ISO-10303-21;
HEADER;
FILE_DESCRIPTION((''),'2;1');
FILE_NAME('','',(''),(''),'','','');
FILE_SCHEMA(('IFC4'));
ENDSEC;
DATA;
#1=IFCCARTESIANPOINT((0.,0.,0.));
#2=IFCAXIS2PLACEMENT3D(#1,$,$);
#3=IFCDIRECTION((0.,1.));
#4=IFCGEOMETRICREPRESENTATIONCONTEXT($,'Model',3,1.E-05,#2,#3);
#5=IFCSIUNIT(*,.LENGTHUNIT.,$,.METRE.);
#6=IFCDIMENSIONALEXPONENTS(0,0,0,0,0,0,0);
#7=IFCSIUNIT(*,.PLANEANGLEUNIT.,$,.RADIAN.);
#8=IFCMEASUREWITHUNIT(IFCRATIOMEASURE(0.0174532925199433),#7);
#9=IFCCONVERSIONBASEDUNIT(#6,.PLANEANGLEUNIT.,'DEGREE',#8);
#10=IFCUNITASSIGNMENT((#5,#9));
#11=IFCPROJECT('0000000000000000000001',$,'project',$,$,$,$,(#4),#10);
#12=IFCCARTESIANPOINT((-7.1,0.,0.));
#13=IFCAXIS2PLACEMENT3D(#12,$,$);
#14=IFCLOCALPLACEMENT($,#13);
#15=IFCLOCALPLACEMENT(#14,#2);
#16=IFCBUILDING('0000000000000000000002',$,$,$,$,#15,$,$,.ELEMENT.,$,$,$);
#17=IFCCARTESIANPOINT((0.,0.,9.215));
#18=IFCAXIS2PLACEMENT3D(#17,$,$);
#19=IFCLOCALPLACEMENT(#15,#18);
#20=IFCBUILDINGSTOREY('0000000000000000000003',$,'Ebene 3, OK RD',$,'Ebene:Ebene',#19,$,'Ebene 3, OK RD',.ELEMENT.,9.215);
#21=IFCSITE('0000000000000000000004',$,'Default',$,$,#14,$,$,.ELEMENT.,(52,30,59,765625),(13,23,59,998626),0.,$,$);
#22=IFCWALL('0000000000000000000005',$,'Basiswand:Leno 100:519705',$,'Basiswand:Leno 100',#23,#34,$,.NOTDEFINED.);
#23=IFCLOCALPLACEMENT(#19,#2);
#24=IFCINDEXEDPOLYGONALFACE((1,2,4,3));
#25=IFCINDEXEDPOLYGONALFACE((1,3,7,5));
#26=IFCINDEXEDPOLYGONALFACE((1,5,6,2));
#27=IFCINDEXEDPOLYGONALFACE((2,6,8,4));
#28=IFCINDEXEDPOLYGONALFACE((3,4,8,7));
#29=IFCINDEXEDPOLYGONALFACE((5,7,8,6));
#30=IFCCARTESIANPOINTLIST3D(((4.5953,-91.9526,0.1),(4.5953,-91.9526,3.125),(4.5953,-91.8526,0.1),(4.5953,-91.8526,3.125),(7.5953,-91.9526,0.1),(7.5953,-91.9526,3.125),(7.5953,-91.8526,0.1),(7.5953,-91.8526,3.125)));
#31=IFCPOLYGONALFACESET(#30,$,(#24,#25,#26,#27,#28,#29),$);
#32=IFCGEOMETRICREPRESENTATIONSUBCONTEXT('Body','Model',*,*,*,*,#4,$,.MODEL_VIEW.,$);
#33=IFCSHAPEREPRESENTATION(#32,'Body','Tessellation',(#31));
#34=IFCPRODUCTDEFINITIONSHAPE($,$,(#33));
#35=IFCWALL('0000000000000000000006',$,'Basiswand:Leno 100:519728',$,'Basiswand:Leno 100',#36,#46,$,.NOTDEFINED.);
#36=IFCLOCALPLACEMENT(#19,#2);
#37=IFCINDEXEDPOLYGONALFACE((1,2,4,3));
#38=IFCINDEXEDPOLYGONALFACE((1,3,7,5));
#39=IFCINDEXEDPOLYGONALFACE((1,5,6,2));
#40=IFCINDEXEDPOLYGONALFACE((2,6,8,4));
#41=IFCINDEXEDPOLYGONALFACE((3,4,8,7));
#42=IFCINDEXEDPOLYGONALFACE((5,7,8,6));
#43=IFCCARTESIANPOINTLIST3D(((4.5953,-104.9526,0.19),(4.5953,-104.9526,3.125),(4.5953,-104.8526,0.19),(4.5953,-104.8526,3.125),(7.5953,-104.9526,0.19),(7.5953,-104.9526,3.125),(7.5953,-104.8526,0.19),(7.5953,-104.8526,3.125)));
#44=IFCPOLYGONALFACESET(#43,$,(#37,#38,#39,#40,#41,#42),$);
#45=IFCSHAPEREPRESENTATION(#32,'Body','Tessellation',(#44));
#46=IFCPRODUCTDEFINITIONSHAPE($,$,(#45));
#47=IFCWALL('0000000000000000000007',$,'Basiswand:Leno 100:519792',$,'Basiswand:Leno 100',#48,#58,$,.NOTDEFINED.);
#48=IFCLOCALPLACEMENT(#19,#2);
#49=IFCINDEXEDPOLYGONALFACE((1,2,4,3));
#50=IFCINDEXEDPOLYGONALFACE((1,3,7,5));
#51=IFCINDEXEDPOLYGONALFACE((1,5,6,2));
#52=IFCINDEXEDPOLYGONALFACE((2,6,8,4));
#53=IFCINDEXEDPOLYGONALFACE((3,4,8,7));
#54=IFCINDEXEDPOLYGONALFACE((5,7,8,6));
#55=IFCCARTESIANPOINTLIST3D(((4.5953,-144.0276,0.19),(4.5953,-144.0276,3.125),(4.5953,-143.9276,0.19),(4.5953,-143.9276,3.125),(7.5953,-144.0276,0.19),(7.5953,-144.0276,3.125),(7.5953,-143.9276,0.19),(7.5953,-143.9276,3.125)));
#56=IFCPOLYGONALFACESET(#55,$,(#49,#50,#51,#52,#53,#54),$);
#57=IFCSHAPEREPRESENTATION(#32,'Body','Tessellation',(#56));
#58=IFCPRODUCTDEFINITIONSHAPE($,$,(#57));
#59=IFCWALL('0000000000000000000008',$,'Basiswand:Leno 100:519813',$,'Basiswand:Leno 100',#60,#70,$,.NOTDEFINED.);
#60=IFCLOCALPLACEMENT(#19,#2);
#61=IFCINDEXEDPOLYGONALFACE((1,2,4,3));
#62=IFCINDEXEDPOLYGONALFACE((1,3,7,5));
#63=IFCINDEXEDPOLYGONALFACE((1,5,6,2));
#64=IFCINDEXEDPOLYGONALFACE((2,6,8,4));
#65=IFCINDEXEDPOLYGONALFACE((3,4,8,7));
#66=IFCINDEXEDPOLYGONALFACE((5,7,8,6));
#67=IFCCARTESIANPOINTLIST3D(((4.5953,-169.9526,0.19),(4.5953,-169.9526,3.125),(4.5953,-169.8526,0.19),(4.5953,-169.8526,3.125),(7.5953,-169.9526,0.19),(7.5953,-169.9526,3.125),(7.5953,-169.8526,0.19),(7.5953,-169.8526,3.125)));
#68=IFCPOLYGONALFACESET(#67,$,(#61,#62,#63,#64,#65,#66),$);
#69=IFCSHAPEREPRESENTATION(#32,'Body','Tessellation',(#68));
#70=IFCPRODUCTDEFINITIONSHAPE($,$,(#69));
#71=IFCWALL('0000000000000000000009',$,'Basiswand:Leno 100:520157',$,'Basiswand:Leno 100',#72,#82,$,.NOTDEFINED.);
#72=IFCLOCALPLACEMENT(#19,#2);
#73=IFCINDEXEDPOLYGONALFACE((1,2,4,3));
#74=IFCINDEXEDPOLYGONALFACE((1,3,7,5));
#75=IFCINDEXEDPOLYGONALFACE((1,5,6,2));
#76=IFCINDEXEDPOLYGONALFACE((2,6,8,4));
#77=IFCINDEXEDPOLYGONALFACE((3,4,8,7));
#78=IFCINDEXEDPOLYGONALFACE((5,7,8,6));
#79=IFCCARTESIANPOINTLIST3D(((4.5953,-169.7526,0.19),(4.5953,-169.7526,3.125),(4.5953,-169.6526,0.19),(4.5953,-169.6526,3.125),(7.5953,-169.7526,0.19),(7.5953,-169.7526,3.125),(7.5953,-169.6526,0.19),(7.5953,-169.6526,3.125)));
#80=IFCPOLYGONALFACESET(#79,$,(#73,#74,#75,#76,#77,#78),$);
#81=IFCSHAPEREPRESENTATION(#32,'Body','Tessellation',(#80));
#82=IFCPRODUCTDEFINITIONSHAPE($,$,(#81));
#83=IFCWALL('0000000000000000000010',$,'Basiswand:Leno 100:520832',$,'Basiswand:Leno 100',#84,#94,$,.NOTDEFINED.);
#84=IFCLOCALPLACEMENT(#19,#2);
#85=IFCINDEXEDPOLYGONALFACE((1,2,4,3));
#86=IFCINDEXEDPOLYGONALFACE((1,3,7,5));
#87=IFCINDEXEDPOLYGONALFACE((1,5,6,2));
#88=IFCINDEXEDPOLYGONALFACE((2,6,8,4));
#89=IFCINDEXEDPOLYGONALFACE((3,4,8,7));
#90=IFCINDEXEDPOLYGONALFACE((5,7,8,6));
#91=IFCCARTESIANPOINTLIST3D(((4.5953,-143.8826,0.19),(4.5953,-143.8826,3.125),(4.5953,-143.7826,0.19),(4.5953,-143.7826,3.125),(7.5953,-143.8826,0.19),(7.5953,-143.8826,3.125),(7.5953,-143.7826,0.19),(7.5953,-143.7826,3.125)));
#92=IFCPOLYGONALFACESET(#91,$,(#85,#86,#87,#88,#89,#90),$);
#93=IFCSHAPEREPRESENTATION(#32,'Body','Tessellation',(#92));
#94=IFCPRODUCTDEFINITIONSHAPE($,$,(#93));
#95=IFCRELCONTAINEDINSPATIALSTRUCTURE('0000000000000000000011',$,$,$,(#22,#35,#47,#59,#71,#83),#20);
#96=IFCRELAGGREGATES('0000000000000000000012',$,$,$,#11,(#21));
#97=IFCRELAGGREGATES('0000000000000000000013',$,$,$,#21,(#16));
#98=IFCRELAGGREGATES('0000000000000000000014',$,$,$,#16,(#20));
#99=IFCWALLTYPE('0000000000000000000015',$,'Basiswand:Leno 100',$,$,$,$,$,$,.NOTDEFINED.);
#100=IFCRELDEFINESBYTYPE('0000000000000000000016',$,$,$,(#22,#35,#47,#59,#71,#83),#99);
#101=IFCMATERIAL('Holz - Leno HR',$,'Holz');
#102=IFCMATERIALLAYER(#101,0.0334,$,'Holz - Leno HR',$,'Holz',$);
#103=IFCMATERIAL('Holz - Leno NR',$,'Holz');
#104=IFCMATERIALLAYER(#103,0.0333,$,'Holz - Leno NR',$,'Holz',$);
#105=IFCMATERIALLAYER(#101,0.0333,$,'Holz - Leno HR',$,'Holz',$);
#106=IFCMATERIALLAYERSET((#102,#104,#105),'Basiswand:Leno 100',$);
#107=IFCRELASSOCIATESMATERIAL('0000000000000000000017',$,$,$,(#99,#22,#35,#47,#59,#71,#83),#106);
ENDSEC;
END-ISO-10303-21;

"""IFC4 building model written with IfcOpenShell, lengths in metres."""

from ifc_helpers import new_model, entity, si_unit, converted_unit, direction, frame, origin, place, context, subcontext, project, spatial, indexed_curve, outline, extrude, material, layer, layer_set, type_object, element, save


model = new_model("IFC4")

# Units and contexts
model_context = context("Model", 3, precision=1e-05, world=origin(), true_north=direction((0.0, 1.0)))
body_context = subcontext(model_context, "Body", "Model", "MODEL_VIEW")
ifc_project = project(units=[si_unit("LENGTHUNIT", "METRE"), converted_unit("PLANEANGLEUNIT", "DEGREE", entity("IfcRatioMeasure", 0.0174532925199433), si_unit("PLANEANGLEUNIT", "RADIAN"), dimensions=[0, 0, 0, 0, 0, 0, 0])], contexts=[model_context])

# Site, building, storey
site_placement = place(None, frame((-7.1, 0.0, 0.0)))
site = spatial("IfcSite", under=ifc_project, at=site_placement, Name="Default", CompositionType="ELEMENT", RefLatitude=(52, 30, 59, 765625), RefLongitude=(13, 23, 59, 998626), RefElevation=0.0)
building_placement = place(site_placement, origin())
building = spatial("IfcBuilding", under=site, at=building_placement, CompositionType="ELEMENT")
storey_placement = place(building_placement, frame((0.0, 0.0, 9.215)))
storey = spatial("IfcBuildingStorey", under=building, at=storey_placement, Name="Ebene 3, OK RD", ObjectType="Ebene:Ebene", LongName="Ebene 3, OK RD", CompositionType="ELEMENT", Elevation=9.215)

# Shared definitions
ifc_material_1 = material(Name="Holz - Leno HR", Category="Holz")
ifc_material_2 = material(Name="Holz - Leno NR", Category="Holz")

# Walls
ifc_layer_1 = layer(ifc_material_1, 0.0334, Name="Holz - Leno HR", Category="Holz")
ifc_layer_2 = layer(ifc_material_2, 0.0333, Name="Holz - Leno NR", Category="Holz")
ifc_layer_3 = layer(ifc_material_1, 0.0333, Name="Holz - Leno HR", Category="Holz")
ifc_layer_set_1 = layer_set([ifc_layer_1, ifc_layer_2, ifc_layer_3], Name="Basiswand:Leno 100")
wall_type = type_object("IfcWallType", Name="Basiswand:Leno 100", PredefinedType="NOTDEFINED", material=ifc_layer_set_1)
wall_1_placement = place(storey_placement, frame((7.5953, -91.9026, 0.1), z_axis=(0.0, 0.0, 1.0), x_axis=(-1.0, 0.0, 0.0)))
element("IfcWall", 1, at=wall_1_placement, inside=storey, type_object=wall_type, material=ifc_layer_set_1, Name="Basiswand:Leno 100:519705", ObjectType="Basiswand:Leno 100", PredefinedType="NOTDEFINED", context=body_context, shape_type="SweptSolid", body=[
    extrude(outline(indexed_curve([(3.0, 0.05), (0.0, 0.05), (0.0, -0.05), (3.0, -0.05), (3.0, 0.05)], self_intersect=False)), origin(), (0.0, 0.0, 1.0), 3.025),
])
for number, where, z_axis, x_axis, name in (
    (2, (7.5953, -104.9026, 0.19), (0.0, 0.0, 1.0), (-1.0, 0.0, 0.0), "Basiswand:Leno 100:519728"),
    (3, (7.5953, -143.9776, 0.19), (0.0, 0.0, 1.0), (-1.0, 0.0, 0.0), "Basiswand:Leno 100:519792"),
):
    element("IfcWall", number, at=place(storey_placement, frame(where, z_axis=z_axis, x_axis=x_axis)), inside=storey, type_object=wall_type, material=ifc_layer_set_1, Name=name, ObjectType="Basiswand:Leno 100", PredefinedType="NOTDEFINED", context=body_context, shape_type="SweptSolid", body=[
        extrude(outline(indexed_curve([(3.0, 0.05), (0.0, 0.05), (0.0, -0.05), (3.0, -0.05), (3.0, 0.05)], self_intersect=False)), origin(), (0.0, 0.0, 1.0), 2.935),
    ])
for number, where, z_axis, x_axis, name in (
    (4, (7.5953, -169.9026, 0.19), (0.0, 0.0, 1.0), (-1.0, 0.0, 0.0), "Basiswand:Leno 100:519813"),
    (5, (7.5953, -169.7026, 0.19), (0.0, 0.0, 1.0), (-1.0, 0.0, 0.0), "Basiswand:Leno 100:520157"),
):
    element("IfcWall", number, at=place(storey_placement, frame(where, z_axis=z_axis, x_axis=x_axis)), inside=storey, type_object=wall_type, material=ifc_layer_set_1, Name=name, ObjectType="Basiswand:Leno 100", PredefinedType="NOTDEFINED", context=body_context, shape_type="SweptSolid", body=[
        extrude(outline(indexed_curve([(3.0, 0.05), (0.0, 0.05), (0.0, -0.05), (3.0, -0.05), (3.0, 0.05)], self_intersect=False)), origin(), (0.0, 0.0, 1.0), 2.935),
    ])
wall_2_placement = place(storey_placement, frame((7.5953, -143.8326, 0.19), z_axis=(0.0, 0.0, 1.0), x_axis=(-1.0, 0.0, 0.0)))
element("IfcWall", 6, at=wall_2_placement, inside=storey, type_object=wall_type, material=ifc_layer_set_1, Name="Basiswand:Leno 100:520832", ObjectType="Basiswand:Leno 100", PredefinedType="NOTDEFINED", context=body_context, shape_type="SweptSolid", body=[
    extrude(outline(indexed_curve([(3.0, 0.05), (0.0, 0.05), (0.0, -0.05), (3.0, -0.05), (3.0, 0.05)], self_intersect=False)), origin(), (0.0, 0.0, 1.0), 2.935),
])

save(model, "model.ifc")
